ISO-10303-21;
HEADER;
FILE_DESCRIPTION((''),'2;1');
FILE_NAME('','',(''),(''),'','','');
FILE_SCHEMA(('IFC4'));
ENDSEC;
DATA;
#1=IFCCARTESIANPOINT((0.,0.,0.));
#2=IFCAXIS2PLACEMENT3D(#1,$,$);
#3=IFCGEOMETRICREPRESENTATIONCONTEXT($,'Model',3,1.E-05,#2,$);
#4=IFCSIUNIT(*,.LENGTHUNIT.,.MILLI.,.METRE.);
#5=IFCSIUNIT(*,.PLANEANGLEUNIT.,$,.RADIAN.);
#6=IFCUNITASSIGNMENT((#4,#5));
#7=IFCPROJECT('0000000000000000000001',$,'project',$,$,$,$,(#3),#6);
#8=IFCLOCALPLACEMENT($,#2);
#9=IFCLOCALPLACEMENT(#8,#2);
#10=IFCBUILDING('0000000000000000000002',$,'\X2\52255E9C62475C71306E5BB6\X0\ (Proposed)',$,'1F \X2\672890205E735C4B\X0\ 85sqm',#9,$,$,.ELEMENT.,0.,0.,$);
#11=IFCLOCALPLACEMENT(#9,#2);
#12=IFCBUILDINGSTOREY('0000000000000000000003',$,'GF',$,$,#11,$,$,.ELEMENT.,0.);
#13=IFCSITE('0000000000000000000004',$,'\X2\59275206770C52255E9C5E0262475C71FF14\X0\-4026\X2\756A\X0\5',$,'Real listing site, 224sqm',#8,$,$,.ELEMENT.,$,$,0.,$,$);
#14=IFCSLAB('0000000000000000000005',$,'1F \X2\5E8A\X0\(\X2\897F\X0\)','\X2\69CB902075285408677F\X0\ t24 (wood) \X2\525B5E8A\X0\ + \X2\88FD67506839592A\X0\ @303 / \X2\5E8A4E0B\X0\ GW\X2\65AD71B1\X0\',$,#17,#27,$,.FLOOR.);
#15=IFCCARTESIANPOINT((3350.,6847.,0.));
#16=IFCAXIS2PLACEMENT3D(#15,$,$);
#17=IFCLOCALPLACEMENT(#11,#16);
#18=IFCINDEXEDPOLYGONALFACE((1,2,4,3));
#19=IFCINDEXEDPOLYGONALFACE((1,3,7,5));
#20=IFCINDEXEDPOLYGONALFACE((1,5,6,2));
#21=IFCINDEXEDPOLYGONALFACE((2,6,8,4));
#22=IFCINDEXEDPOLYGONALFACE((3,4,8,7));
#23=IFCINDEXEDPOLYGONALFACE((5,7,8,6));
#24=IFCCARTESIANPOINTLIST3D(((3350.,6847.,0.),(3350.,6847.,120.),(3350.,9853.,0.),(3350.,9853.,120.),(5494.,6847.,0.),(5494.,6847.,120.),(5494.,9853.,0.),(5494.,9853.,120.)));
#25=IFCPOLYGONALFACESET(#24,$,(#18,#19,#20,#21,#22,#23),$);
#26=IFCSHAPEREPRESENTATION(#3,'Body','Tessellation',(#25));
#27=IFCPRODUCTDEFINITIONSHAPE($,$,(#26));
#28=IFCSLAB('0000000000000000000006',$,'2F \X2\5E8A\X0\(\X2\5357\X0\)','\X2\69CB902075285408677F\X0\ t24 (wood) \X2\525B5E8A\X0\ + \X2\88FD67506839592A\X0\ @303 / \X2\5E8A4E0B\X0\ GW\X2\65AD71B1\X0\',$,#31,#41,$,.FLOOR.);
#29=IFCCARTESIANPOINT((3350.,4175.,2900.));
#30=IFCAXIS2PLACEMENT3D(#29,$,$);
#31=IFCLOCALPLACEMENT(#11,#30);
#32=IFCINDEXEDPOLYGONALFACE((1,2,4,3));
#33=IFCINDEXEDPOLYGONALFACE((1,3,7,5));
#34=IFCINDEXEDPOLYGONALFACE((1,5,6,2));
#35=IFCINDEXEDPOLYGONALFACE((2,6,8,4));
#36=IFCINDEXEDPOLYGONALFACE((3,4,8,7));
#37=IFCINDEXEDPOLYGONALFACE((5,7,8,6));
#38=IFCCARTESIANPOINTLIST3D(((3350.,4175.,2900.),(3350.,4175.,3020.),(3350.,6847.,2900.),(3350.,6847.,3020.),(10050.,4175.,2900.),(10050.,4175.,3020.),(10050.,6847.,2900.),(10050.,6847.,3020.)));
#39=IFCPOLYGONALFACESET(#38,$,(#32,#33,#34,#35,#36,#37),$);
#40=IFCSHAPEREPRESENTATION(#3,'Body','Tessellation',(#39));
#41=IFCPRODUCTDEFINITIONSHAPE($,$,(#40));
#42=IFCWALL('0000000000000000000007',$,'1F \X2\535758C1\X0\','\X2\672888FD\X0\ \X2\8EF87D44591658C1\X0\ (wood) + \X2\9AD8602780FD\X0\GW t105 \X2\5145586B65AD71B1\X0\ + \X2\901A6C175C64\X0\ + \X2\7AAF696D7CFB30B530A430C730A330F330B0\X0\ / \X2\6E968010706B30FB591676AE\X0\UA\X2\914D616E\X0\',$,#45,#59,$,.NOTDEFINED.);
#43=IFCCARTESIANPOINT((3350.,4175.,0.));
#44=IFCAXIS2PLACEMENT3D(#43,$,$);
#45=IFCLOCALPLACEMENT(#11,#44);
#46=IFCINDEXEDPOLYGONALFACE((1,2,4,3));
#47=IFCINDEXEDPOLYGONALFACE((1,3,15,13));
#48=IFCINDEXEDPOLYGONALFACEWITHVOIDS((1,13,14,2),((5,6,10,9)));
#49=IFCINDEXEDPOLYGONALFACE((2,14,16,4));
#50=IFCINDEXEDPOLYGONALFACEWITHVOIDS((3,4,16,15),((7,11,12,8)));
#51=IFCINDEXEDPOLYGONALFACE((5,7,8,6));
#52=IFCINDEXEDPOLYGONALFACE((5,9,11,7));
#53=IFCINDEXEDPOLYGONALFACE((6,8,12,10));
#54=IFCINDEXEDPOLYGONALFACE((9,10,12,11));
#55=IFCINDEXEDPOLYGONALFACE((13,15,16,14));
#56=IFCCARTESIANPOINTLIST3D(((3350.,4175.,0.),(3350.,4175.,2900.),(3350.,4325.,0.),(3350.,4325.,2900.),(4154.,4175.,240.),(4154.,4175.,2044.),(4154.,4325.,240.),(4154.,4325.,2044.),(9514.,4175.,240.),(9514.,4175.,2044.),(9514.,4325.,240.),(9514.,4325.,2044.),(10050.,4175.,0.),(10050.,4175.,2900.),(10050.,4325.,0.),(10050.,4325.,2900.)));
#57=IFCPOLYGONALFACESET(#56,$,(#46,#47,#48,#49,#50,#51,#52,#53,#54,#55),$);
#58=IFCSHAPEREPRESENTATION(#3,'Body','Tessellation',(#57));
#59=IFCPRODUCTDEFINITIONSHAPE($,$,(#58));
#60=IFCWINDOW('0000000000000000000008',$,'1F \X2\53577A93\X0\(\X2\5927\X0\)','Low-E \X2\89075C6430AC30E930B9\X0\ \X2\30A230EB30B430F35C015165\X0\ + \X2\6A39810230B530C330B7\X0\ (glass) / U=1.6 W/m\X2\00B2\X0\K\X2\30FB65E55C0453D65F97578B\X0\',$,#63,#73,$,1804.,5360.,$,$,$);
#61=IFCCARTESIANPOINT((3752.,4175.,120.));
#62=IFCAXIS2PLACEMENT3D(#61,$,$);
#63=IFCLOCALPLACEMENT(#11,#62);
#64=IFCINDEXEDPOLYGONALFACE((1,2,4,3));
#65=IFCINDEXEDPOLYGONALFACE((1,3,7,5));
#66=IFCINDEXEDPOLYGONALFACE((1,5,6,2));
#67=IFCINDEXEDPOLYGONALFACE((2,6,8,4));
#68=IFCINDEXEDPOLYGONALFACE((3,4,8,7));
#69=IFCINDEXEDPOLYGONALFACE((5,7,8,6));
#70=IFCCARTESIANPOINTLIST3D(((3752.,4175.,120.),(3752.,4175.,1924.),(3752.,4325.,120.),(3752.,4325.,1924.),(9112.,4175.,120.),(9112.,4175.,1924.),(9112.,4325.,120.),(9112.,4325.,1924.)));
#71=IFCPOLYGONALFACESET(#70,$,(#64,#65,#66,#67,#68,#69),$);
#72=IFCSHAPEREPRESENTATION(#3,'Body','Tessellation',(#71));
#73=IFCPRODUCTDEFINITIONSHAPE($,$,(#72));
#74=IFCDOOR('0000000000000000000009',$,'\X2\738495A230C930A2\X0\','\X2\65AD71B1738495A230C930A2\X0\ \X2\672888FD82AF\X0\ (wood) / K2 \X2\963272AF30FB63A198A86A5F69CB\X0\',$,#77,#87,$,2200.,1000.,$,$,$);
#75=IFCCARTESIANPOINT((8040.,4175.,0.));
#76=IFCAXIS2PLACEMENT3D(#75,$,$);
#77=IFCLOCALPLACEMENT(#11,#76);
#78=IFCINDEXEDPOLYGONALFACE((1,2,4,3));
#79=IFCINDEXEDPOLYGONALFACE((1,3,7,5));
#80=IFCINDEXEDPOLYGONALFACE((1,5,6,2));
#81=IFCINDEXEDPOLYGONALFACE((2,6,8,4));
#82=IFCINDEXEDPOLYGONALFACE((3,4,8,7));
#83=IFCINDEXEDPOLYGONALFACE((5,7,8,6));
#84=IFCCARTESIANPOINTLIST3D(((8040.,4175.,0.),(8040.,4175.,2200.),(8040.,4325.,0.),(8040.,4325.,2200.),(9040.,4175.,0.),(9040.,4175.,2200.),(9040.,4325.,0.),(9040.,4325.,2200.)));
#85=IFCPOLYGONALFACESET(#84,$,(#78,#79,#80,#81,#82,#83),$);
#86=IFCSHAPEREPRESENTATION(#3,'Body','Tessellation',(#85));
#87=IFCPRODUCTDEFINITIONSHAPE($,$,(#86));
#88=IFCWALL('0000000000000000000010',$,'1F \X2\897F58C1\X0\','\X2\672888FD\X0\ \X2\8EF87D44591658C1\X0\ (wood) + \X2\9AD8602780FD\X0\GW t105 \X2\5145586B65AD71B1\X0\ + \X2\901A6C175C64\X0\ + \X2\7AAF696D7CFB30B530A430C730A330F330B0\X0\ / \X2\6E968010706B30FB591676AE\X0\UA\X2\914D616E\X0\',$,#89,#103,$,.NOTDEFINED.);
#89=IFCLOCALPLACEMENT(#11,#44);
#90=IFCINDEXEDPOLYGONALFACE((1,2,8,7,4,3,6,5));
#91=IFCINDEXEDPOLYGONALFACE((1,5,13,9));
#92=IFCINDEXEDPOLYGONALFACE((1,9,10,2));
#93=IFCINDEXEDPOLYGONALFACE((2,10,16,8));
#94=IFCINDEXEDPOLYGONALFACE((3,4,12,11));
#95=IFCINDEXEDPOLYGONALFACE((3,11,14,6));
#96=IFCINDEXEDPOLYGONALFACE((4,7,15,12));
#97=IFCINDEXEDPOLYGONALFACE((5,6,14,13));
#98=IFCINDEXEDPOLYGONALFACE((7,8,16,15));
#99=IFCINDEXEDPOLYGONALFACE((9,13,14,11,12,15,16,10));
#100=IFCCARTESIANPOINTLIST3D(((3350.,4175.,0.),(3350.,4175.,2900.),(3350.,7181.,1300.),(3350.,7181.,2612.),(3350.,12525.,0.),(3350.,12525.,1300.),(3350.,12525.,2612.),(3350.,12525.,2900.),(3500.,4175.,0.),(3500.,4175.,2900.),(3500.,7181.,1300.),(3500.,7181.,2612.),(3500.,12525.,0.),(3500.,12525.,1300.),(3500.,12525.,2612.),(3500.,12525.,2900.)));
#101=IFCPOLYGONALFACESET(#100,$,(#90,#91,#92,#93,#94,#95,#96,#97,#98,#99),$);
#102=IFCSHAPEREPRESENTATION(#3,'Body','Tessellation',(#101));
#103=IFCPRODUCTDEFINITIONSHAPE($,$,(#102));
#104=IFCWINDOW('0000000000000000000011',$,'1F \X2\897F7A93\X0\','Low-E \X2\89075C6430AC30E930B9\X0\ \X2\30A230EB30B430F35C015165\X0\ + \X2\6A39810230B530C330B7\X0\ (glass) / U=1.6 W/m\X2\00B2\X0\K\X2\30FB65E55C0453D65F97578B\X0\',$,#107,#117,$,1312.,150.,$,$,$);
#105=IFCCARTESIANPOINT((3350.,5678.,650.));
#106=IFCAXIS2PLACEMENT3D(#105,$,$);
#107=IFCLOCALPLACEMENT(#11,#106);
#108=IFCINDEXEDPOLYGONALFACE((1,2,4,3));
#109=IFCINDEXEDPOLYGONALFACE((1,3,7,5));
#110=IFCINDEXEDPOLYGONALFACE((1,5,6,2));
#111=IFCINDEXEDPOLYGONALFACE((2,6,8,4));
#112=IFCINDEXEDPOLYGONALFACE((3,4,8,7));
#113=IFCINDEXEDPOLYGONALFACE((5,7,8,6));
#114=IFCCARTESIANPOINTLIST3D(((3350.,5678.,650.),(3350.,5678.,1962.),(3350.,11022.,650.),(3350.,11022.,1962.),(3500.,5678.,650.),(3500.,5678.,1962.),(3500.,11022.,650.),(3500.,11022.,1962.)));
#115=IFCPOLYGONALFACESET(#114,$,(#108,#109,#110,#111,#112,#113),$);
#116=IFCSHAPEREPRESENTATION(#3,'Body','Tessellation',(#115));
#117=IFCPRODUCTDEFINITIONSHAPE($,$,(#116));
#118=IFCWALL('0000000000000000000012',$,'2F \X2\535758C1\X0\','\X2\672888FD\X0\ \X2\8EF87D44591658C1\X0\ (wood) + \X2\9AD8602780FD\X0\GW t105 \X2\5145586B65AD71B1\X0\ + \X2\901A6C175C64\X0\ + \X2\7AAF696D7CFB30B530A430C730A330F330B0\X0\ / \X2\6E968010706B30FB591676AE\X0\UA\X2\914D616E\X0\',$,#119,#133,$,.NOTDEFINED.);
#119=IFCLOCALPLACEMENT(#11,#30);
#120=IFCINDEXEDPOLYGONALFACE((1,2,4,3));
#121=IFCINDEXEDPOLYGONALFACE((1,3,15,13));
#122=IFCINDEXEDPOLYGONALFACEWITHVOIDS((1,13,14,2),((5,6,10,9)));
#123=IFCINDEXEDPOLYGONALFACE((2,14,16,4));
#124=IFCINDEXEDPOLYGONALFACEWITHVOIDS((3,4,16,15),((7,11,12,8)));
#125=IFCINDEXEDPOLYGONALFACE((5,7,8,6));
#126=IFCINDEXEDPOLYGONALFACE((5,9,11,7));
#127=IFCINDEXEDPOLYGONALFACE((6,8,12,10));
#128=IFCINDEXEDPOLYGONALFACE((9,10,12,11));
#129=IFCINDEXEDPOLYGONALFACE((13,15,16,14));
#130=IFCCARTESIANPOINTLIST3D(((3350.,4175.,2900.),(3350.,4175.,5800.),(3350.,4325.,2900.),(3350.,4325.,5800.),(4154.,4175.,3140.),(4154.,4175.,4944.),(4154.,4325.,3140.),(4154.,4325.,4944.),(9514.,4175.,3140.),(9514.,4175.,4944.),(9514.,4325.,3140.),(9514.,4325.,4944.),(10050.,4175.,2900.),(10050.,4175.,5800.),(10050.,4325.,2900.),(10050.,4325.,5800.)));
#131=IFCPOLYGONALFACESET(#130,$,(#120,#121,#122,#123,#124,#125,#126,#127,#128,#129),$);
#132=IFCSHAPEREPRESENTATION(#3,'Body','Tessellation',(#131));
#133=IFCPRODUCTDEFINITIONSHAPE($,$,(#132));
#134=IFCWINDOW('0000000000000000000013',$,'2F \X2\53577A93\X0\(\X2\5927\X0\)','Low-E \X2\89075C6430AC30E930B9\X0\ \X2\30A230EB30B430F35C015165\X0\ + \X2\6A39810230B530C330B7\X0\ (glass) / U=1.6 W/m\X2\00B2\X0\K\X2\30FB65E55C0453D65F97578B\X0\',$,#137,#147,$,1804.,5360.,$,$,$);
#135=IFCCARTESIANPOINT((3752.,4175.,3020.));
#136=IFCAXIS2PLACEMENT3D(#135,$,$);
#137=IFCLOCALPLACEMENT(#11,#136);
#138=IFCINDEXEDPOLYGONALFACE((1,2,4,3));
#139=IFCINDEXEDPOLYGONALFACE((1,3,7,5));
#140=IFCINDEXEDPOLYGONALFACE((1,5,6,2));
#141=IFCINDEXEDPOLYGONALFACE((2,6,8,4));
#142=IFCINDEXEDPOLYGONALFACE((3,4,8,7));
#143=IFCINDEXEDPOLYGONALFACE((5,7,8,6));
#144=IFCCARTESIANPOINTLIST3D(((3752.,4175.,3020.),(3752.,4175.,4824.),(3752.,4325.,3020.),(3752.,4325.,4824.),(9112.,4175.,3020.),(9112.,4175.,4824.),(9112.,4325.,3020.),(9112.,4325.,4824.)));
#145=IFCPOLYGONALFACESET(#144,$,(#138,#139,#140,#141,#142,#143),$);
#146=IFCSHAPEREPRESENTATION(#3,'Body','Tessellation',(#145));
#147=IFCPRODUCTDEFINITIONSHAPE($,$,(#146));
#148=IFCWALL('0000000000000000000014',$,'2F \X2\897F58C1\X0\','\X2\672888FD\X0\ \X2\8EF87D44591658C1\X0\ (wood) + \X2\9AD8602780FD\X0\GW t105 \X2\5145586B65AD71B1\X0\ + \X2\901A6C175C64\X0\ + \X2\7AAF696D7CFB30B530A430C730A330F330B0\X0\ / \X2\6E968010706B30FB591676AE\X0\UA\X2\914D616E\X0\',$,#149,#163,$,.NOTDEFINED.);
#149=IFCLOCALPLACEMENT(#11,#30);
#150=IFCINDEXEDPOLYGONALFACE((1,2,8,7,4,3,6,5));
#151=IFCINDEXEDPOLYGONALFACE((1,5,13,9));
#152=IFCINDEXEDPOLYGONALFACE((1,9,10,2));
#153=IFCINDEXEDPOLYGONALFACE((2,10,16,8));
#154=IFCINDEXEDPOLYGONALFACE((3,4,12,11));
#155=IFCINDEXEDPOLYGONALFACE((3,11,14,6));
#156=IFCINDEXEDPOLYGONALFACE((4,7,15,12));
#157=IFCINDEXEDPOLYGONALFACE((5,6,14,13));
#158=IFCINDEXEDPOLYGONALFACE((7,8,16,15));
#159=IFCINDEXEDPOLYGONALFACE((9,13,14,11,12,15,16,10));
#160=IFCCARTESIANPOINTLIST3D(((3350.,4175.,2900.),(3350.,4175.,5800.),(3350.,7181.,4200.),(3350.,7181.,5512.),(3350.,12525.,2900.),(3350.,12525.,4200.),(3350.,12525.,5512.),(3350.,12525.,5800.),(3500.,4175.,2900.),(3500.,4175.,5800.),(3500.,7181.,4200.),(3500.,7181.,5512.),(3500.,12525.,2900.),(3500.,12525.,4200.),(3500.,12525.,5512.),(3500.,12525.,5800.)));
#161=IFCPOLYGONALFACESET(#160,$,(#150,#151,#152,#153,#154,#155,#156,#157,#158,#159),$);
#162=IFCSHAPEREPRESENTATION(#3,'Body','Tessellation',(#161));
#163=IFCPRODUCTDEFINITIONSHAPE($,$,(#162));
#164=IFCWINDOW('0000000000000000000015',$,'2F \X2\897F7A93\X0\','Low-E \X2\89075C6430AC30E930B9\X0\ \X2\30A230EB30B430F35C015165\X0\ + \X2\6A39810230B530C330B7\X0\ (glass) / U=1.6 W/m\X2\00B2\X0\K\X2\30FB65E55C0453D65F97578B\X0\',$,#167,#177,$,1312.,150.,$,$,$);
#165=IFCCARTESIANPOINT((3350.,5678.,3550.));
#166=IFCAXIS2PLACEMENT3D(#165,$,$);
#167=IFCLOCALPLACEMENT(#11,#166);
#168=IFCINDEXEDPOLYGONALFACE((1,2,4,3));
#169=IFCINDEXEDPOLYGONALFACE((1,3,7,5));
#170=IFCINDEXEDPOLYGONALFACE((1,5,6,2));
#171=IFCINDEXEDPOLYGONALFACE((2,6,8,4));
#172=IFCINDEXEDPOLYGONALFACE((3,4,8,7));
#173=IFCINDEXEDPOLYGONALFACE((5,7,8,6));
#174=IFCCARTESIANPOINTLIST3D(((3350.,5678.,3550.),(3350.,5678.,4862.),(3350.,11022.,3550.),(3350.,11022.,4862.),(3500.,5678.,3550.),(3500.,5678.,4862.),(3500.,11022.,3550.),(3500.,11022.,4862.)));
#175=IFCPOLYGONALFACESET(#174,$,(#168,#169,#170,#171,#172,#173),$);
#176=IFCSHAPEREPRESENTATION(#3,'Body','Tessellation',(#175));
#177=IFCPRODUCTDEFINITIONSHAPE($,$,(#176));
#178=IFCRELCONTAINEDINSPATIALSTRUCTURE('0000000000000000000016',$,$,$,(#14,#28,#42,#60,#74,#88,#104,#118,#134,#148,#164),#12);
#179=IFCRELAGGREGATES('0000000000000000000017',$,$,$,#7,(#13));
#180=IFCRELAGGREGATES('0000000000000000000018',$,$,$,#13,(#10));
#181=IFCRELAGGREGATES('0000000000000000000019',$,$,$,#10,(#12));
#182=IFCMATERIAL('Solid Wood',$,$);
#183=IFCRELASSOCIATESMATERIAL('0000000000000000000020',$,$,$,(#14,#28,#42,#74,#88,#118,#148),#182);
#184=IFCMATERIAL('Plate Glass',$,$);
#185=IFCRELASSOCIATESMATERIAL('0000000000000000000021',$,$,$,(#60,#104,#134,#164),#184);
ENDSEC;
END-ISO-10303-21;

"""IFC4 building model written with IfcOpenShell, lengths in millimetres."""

from ifc_helpers import new_model, si_unit, frame, frame_2d, origin, place, context, project, spatial, rectangle, extrude, material, element, fill, save


model = new_model("IFC4")

# Units and contexts
model_context = context("Model", 3, precision=1e-05, world=origin())
ifc_project = project(units=[si_unit("LENGTHUNIT", "METRE", prefix="MILLI"), si_unit("PLANEANGLEUNIT", "RADIAN")], contexts=[model_context])

# Site, building, storey
site_placement = place(None, origin())
site = spatial("IfcSite", under=ifc_project, at=site_placement, Name="大分県別府市扇山４-4026番5", ObjectType="Real listing site, 224sqm", CompositionType="ELEMENT", RefElevation=0.0)
building_placement = place(site_placement, origin())
building = spatial("IfcBuilding", under=site, at=building_placement, Name="別府扇山の家 (Proposed)", ObjectType="1F 木造平屋 85sqm", CompositionType="ELEMENT", ElevationOfRefHeight=0.0, ElevationOfTerrain=0.0)
storey_placement = place(building_placement, origin())
storey = spatial("IfcBuildingStorey", under=building, at=storey_placement, Name="GF", CompositionType="ELEMENT", Elevation=0.0)

# Slabs
ifc_material_1 = material(Name="Solid Wood")
slab_1_placement = place(storey_placement, frame((3350.0, 6847.0, 0.0)))
element("IfcSlab", 1, at=slab_1_placement, inside=storey, material=ifc_material_1, Name="1F 床(西)", Description="構造用合板 t24 (wood) 剛床 + 製材根太 @303 / 床下 GW断熱", PredefinedType="FLOOR", context=model_context, shape_type="SweptSolid", body=[
    extrude(rectangle(XDim=2144.0, YDim=3006.0, at=frame_2d((1072.0, 1503.0))), frame((3350.0, 6847.0, 0.0)), (0.0, 0.0, 1.0), 120.0),
])
slab_2_placement = place(storey_placement, frame((3350.0, 4175.0, 2900.0)))
element("IfcSlab", 2, at=slab_2_placement, inside=storey, material=ifc_material_1, Name="2F 床(南)", Description="構造用合板 t24 (wood) 剛床 + 製材根太 @303 / 床下 GW断熱", PredefinedType="FLOOR", context=model_context, shape_type="SweptSolid", body=[
    extrude(rectangle(XDim=6700.0, YDim=2672.0, at=frame_2d((3350.0, 1336.0))), frame((3350.0, 4175.0, 2900.0)), (0.0, 0.0, 1.0), 120.0),
])

# Wall, openings, window, door
wall_1_placement = place(storey_placement, frame((3350.0, 4175.0, 0.0)))
wall_1 = element("IfcWall", 3, at=wall_1_placement, inside=storey, material=ifc_material_1, Name="1F 南壁", Description="木製 軸組外壁 (wood) + 高性能GW t105 充填断熱 + 通気層 + 窯業系サイディング / 準耐火・外皮UA配慮", PredefinedType="NOTDEFINED", context=model_context, shape_type="SweptSolid", body=[
    extrude(rectangle(XDim=6700.0, YDim=150.0, at=frame_2d((3350.0, 75.0))), frame((3350.0, 4175.0, 0.0)), (0.0, 0.0, 1.0), 2900.0),
])
opening_1_placement = place(storey_placement, frame((3752.0, 4175.0, 120.0)))
opening_1 = element("IfcOpeningElement", 4, at=opening_1_placement, cuts=wall_1, PredefinedType="NOTDEFINED", context=model_context, shape_type="SweptSolid", body=[
    extrude(rectangle(XDim=5360.0, YDim=150.0, at=frame_2d((2680.0, 75.0))), frame((3752.0, 4175.0, 120.0)), (0.0, 0.0, 1.0), 1804.0),
])
opening_2_placement = place(storey_placement, frame((8040.0, 4175.0, 0.0)))
opening_2 = element("IfcOpeningElement", 5, at=opening_2_placement, cuts=wall_1, PredefinedType="NOTDEFINED", context=model_context, shape_type="SweptSolid", body=[
    extrude(rectangle(XDim=1000.0, YDim=150.0, at=frame_2d((500.0, 75.0))), frame((8040.0, 4175.0, 0.0)), (0.0, 0.0, 1.0), 2200.0),
])
ifc_material_2 = material(Name="Plate Glass")
window_1_placement = place(storey_placement, frame((3752.0, 4175.0, 120.0)))
window_1 = element("IfcWindow", 6, at=window_1_placement, inside=storey, material=ifc_material_2, Name="1F 南窓(大)", Description="Low-E 複層ガラス アルゴン封入 + 樹脂サッシ (glass) / U=1.6 W/m²K・日射取得型", OverallHeight=1804.0, OverallWidth=5360.0, context=model_context, shape_type="SweptSolid", body=[
    extrude(rectangle(XDim=5360.0, YDim=150.0, at=frame_2d((2680.0, 75.0))), frame((3752.0, 4175.0, 120.0)), (0.0, 0.0, 1.0), 1804.0),
])
fill(opening_1, window_1)
door_placement = place(storey_placement, frame((8040.0, 4175.0, 0.0)))
door = element("IfcDoor", 7, at=door_placement, inside=storey, material=ifc_material_1, Name="玄関ドア", Description="断熱玄関ドア 木製芯 (wood) / K2 防犯・採風機構", OverallHeight=2200.0, OverallWidth=1000.0, context=model_context, shape_type="SweptSolid", body=[
    extrude(rectangle(XDim=1000.0, YDim=150.0, at=frame_2d((500.0, 75.0))), frame((8040.0, 4175.0, 0.0)), (0.0, 0.0, 1.0), 2200.0),
])
fill(opening_2, door)

# Walls, openings, windows
wall_2_placement = place(storey_placement, frame((3350.0, 4175.0, 0.0)))
wall_2 = element("IfcWall", 8, at=wall_2_placement, inside=storey, material=ifc_material_1, Name="1F 西壁", Description="木製 軸組外壁 (wood) + 高性能GW t105 充填断熱 + 通気層 + 窯業系サイディング / 準耐火・外皮UA配慮", PredefinedType="NOTDEFINED", context=model_context, shape_type="SweptSolid", body=[
    extrude(rectangle(XDim=150.0, YDim=8350.0, at=frame_2d((75.0, 4175.0))), frame((3350.0, 4175.0, 0.0)), (0.0, 0.0, 1.0), 2900.0),
])
opening_3_placement = place(storey_placement, frame((3350.0, 5678.0, 650.0)))
opening_3 = element("IfcOpeningElement", 9, at=opening_3_placement, cuts=wall_2, PredefinedType="NOTDEFINED", context=model_context, shape_type="SweptSolid", body=[
    extrude(rectangle(XDim=150.0, YDim=5344.0, at=frame_2d((75.0, 2672.0))), frame((3350.0, 5678.0, 650.0)), (0.0, 0.0, 1.0), 1312.0),
])
window_2_placement = place(storey_placement, frame((3350.0, 5678.0, 650.0)))
window_2 = element("IfcWindow", 10, at=window_2_placement, inside=storey, material=ifc_material_2, Name="1F 西窓", Description="Low-E 複層ガラス アルゴン封入 + 樹脂サッシ (glass) / U=1.6 W/m²K・日射取得型", OverallHeight=1312.0, OverallWidth=150.0, context=model_context, shape_type="SweptSolid", body=[
    extrude(rectangle(XDim=150.0, YDim=5344.0, at=frame_2d((75.0, 2672.0))), frame((3350.0, 5678.0, 650.0)), (0.0, 0.0, 1.0), 1312.0),
])
fill(opening_3, window_2)
wall_3_placement = place(storey_placement, frame((3350.0, 4175.0, 2900.0)))
wall_3 = element("IfcWall", 11, at=wall_3_placement, inside=storey, material=ifc_material_1, Name="2F 南壁", Description="木製 軸組外壁 (wood) + 高性能GW t105 充填断熱 + 通気層 + 窯業系サイディング / 準耐火・外皮UA配慮", PredefinedType="NOTDEFINED", context=model_context, shape_type="SweptSolid", body=[
    extrude(rectangle(XDim=6700.0, YDim=150.0, at=frame_2d((3350.0, 75.0))), frame((3350.0, 4175.0, 2900.0)), (0.0, 0.0, 1.0), 2900.0),
])
opening_4_placement = place(storey_placement, frame((3752.0, 4175.0, 3020.0)))
opening_4 = element("IfcOpeningElement", 12, at=opening_4_placement, cuts=wall_3, PredefinedType="NOTDEFINED", context=model_context, shape_type="SweptSolid", body=[
    extrude(rectangle(XDim=5360.0, YDim=150.0, at=frame_2d((2680.0, 75.0))), frame((3752.0, 4175.0, 3020.0)), (0.0, 0.0, 1.0), 1804.0),
])
window_3_placement = place(storey_placement, frame((3752.0, 4175.0, 3020.0)))
window_3 = element("IfcWindow", 13, at=window_3_placement, inside=storey, material=ifc_material_2, Name="2F 南窓(大)", Description="Low-E 複層ガラス アルゴン封入 + 樹脂サッシ (glass) / U=1.6 W/m²K・日射取得型", OverallHeight=1804.0, OverallWidth=5360.0, context=model_context, shape_type="SweptSolid", body=[
    extrude(rectangle(XDim=5360.0, YDim=150.0, at=frame_2d((2680.0, 75.0))), frame((3752.0, 4175.0, 3020.0)), (0.0, 0.0, 1.0), 1804.0),
])
fill(opening_4, window_3)
wall_4_placement = place(storey_placement, frame((3350.0, 4175.0, 2900.0)))
wall_4 = element("IfcWall", 14, at=wall_4_placement, inside=storey, material=ifc_material_1, Name="2F 西壁", Description="木製 軸組外壁 (wood) + 高性能GW t105 充填断熱 + 通気層 + 窯業系サイディング / 準耐火・外皮UA配慮", PredefinedType="NOTDEFINED", context=model_context, shape_type="SweptSolid", body=[
    extrude(rectangle(XDim=150.0, YDim=8350.0, at=frame_2d((75.0, 4175.0))), frame((3350.0, 4175.0, 2900.0)), (0.0, 0.0, 1.0), 2900.0),
])
opening_5_placement = place(storey_placement, frame((3350.0, 5678.0, 3550.0)))
opening_5 = element("IfcOpeningElement", 15, at=opening_5_placement, cuts=wall_4, PredefinedType="NOTDEFINED", context=model_context, shape_type="SweptSolid", body=[
    extrude(rectangle(XDim=150.0, YDim=5344.0, at=frame_2d((75.0, 2672.0))), frame((3350.0, 5678.0, 3550.0)), (0.0, 0.0, 1.0), 1312.0),
])
window_4_placement = place(storey_placement, frame((3350.0, 5678.0, 3550.0)))
window_4 = element("IfcWindow", 16, at=window_4_placement, inside=storey, material=ifc_material_2, Name="2F 西窓", Description="Low-E 複層ガラス アルゴン封入 + 樹脂サッシ (glass) / U=1.6 W/m²K・日射取得型", OverallHeight=1312.0, OverallWidth=150.0, context=model_context, shape_type="SweptSolid", body=[
    extrude(rectangle(XDim=150.0, YDim=5344.0, at=frame_2d((75.0, 2672.0))), frame((3350.0, 5678.0, 3550.0)), (0.0, 0.0, 1.0), 1312.0),
])
fill(opening_5, window_4)

save(model, "model.ifc")
